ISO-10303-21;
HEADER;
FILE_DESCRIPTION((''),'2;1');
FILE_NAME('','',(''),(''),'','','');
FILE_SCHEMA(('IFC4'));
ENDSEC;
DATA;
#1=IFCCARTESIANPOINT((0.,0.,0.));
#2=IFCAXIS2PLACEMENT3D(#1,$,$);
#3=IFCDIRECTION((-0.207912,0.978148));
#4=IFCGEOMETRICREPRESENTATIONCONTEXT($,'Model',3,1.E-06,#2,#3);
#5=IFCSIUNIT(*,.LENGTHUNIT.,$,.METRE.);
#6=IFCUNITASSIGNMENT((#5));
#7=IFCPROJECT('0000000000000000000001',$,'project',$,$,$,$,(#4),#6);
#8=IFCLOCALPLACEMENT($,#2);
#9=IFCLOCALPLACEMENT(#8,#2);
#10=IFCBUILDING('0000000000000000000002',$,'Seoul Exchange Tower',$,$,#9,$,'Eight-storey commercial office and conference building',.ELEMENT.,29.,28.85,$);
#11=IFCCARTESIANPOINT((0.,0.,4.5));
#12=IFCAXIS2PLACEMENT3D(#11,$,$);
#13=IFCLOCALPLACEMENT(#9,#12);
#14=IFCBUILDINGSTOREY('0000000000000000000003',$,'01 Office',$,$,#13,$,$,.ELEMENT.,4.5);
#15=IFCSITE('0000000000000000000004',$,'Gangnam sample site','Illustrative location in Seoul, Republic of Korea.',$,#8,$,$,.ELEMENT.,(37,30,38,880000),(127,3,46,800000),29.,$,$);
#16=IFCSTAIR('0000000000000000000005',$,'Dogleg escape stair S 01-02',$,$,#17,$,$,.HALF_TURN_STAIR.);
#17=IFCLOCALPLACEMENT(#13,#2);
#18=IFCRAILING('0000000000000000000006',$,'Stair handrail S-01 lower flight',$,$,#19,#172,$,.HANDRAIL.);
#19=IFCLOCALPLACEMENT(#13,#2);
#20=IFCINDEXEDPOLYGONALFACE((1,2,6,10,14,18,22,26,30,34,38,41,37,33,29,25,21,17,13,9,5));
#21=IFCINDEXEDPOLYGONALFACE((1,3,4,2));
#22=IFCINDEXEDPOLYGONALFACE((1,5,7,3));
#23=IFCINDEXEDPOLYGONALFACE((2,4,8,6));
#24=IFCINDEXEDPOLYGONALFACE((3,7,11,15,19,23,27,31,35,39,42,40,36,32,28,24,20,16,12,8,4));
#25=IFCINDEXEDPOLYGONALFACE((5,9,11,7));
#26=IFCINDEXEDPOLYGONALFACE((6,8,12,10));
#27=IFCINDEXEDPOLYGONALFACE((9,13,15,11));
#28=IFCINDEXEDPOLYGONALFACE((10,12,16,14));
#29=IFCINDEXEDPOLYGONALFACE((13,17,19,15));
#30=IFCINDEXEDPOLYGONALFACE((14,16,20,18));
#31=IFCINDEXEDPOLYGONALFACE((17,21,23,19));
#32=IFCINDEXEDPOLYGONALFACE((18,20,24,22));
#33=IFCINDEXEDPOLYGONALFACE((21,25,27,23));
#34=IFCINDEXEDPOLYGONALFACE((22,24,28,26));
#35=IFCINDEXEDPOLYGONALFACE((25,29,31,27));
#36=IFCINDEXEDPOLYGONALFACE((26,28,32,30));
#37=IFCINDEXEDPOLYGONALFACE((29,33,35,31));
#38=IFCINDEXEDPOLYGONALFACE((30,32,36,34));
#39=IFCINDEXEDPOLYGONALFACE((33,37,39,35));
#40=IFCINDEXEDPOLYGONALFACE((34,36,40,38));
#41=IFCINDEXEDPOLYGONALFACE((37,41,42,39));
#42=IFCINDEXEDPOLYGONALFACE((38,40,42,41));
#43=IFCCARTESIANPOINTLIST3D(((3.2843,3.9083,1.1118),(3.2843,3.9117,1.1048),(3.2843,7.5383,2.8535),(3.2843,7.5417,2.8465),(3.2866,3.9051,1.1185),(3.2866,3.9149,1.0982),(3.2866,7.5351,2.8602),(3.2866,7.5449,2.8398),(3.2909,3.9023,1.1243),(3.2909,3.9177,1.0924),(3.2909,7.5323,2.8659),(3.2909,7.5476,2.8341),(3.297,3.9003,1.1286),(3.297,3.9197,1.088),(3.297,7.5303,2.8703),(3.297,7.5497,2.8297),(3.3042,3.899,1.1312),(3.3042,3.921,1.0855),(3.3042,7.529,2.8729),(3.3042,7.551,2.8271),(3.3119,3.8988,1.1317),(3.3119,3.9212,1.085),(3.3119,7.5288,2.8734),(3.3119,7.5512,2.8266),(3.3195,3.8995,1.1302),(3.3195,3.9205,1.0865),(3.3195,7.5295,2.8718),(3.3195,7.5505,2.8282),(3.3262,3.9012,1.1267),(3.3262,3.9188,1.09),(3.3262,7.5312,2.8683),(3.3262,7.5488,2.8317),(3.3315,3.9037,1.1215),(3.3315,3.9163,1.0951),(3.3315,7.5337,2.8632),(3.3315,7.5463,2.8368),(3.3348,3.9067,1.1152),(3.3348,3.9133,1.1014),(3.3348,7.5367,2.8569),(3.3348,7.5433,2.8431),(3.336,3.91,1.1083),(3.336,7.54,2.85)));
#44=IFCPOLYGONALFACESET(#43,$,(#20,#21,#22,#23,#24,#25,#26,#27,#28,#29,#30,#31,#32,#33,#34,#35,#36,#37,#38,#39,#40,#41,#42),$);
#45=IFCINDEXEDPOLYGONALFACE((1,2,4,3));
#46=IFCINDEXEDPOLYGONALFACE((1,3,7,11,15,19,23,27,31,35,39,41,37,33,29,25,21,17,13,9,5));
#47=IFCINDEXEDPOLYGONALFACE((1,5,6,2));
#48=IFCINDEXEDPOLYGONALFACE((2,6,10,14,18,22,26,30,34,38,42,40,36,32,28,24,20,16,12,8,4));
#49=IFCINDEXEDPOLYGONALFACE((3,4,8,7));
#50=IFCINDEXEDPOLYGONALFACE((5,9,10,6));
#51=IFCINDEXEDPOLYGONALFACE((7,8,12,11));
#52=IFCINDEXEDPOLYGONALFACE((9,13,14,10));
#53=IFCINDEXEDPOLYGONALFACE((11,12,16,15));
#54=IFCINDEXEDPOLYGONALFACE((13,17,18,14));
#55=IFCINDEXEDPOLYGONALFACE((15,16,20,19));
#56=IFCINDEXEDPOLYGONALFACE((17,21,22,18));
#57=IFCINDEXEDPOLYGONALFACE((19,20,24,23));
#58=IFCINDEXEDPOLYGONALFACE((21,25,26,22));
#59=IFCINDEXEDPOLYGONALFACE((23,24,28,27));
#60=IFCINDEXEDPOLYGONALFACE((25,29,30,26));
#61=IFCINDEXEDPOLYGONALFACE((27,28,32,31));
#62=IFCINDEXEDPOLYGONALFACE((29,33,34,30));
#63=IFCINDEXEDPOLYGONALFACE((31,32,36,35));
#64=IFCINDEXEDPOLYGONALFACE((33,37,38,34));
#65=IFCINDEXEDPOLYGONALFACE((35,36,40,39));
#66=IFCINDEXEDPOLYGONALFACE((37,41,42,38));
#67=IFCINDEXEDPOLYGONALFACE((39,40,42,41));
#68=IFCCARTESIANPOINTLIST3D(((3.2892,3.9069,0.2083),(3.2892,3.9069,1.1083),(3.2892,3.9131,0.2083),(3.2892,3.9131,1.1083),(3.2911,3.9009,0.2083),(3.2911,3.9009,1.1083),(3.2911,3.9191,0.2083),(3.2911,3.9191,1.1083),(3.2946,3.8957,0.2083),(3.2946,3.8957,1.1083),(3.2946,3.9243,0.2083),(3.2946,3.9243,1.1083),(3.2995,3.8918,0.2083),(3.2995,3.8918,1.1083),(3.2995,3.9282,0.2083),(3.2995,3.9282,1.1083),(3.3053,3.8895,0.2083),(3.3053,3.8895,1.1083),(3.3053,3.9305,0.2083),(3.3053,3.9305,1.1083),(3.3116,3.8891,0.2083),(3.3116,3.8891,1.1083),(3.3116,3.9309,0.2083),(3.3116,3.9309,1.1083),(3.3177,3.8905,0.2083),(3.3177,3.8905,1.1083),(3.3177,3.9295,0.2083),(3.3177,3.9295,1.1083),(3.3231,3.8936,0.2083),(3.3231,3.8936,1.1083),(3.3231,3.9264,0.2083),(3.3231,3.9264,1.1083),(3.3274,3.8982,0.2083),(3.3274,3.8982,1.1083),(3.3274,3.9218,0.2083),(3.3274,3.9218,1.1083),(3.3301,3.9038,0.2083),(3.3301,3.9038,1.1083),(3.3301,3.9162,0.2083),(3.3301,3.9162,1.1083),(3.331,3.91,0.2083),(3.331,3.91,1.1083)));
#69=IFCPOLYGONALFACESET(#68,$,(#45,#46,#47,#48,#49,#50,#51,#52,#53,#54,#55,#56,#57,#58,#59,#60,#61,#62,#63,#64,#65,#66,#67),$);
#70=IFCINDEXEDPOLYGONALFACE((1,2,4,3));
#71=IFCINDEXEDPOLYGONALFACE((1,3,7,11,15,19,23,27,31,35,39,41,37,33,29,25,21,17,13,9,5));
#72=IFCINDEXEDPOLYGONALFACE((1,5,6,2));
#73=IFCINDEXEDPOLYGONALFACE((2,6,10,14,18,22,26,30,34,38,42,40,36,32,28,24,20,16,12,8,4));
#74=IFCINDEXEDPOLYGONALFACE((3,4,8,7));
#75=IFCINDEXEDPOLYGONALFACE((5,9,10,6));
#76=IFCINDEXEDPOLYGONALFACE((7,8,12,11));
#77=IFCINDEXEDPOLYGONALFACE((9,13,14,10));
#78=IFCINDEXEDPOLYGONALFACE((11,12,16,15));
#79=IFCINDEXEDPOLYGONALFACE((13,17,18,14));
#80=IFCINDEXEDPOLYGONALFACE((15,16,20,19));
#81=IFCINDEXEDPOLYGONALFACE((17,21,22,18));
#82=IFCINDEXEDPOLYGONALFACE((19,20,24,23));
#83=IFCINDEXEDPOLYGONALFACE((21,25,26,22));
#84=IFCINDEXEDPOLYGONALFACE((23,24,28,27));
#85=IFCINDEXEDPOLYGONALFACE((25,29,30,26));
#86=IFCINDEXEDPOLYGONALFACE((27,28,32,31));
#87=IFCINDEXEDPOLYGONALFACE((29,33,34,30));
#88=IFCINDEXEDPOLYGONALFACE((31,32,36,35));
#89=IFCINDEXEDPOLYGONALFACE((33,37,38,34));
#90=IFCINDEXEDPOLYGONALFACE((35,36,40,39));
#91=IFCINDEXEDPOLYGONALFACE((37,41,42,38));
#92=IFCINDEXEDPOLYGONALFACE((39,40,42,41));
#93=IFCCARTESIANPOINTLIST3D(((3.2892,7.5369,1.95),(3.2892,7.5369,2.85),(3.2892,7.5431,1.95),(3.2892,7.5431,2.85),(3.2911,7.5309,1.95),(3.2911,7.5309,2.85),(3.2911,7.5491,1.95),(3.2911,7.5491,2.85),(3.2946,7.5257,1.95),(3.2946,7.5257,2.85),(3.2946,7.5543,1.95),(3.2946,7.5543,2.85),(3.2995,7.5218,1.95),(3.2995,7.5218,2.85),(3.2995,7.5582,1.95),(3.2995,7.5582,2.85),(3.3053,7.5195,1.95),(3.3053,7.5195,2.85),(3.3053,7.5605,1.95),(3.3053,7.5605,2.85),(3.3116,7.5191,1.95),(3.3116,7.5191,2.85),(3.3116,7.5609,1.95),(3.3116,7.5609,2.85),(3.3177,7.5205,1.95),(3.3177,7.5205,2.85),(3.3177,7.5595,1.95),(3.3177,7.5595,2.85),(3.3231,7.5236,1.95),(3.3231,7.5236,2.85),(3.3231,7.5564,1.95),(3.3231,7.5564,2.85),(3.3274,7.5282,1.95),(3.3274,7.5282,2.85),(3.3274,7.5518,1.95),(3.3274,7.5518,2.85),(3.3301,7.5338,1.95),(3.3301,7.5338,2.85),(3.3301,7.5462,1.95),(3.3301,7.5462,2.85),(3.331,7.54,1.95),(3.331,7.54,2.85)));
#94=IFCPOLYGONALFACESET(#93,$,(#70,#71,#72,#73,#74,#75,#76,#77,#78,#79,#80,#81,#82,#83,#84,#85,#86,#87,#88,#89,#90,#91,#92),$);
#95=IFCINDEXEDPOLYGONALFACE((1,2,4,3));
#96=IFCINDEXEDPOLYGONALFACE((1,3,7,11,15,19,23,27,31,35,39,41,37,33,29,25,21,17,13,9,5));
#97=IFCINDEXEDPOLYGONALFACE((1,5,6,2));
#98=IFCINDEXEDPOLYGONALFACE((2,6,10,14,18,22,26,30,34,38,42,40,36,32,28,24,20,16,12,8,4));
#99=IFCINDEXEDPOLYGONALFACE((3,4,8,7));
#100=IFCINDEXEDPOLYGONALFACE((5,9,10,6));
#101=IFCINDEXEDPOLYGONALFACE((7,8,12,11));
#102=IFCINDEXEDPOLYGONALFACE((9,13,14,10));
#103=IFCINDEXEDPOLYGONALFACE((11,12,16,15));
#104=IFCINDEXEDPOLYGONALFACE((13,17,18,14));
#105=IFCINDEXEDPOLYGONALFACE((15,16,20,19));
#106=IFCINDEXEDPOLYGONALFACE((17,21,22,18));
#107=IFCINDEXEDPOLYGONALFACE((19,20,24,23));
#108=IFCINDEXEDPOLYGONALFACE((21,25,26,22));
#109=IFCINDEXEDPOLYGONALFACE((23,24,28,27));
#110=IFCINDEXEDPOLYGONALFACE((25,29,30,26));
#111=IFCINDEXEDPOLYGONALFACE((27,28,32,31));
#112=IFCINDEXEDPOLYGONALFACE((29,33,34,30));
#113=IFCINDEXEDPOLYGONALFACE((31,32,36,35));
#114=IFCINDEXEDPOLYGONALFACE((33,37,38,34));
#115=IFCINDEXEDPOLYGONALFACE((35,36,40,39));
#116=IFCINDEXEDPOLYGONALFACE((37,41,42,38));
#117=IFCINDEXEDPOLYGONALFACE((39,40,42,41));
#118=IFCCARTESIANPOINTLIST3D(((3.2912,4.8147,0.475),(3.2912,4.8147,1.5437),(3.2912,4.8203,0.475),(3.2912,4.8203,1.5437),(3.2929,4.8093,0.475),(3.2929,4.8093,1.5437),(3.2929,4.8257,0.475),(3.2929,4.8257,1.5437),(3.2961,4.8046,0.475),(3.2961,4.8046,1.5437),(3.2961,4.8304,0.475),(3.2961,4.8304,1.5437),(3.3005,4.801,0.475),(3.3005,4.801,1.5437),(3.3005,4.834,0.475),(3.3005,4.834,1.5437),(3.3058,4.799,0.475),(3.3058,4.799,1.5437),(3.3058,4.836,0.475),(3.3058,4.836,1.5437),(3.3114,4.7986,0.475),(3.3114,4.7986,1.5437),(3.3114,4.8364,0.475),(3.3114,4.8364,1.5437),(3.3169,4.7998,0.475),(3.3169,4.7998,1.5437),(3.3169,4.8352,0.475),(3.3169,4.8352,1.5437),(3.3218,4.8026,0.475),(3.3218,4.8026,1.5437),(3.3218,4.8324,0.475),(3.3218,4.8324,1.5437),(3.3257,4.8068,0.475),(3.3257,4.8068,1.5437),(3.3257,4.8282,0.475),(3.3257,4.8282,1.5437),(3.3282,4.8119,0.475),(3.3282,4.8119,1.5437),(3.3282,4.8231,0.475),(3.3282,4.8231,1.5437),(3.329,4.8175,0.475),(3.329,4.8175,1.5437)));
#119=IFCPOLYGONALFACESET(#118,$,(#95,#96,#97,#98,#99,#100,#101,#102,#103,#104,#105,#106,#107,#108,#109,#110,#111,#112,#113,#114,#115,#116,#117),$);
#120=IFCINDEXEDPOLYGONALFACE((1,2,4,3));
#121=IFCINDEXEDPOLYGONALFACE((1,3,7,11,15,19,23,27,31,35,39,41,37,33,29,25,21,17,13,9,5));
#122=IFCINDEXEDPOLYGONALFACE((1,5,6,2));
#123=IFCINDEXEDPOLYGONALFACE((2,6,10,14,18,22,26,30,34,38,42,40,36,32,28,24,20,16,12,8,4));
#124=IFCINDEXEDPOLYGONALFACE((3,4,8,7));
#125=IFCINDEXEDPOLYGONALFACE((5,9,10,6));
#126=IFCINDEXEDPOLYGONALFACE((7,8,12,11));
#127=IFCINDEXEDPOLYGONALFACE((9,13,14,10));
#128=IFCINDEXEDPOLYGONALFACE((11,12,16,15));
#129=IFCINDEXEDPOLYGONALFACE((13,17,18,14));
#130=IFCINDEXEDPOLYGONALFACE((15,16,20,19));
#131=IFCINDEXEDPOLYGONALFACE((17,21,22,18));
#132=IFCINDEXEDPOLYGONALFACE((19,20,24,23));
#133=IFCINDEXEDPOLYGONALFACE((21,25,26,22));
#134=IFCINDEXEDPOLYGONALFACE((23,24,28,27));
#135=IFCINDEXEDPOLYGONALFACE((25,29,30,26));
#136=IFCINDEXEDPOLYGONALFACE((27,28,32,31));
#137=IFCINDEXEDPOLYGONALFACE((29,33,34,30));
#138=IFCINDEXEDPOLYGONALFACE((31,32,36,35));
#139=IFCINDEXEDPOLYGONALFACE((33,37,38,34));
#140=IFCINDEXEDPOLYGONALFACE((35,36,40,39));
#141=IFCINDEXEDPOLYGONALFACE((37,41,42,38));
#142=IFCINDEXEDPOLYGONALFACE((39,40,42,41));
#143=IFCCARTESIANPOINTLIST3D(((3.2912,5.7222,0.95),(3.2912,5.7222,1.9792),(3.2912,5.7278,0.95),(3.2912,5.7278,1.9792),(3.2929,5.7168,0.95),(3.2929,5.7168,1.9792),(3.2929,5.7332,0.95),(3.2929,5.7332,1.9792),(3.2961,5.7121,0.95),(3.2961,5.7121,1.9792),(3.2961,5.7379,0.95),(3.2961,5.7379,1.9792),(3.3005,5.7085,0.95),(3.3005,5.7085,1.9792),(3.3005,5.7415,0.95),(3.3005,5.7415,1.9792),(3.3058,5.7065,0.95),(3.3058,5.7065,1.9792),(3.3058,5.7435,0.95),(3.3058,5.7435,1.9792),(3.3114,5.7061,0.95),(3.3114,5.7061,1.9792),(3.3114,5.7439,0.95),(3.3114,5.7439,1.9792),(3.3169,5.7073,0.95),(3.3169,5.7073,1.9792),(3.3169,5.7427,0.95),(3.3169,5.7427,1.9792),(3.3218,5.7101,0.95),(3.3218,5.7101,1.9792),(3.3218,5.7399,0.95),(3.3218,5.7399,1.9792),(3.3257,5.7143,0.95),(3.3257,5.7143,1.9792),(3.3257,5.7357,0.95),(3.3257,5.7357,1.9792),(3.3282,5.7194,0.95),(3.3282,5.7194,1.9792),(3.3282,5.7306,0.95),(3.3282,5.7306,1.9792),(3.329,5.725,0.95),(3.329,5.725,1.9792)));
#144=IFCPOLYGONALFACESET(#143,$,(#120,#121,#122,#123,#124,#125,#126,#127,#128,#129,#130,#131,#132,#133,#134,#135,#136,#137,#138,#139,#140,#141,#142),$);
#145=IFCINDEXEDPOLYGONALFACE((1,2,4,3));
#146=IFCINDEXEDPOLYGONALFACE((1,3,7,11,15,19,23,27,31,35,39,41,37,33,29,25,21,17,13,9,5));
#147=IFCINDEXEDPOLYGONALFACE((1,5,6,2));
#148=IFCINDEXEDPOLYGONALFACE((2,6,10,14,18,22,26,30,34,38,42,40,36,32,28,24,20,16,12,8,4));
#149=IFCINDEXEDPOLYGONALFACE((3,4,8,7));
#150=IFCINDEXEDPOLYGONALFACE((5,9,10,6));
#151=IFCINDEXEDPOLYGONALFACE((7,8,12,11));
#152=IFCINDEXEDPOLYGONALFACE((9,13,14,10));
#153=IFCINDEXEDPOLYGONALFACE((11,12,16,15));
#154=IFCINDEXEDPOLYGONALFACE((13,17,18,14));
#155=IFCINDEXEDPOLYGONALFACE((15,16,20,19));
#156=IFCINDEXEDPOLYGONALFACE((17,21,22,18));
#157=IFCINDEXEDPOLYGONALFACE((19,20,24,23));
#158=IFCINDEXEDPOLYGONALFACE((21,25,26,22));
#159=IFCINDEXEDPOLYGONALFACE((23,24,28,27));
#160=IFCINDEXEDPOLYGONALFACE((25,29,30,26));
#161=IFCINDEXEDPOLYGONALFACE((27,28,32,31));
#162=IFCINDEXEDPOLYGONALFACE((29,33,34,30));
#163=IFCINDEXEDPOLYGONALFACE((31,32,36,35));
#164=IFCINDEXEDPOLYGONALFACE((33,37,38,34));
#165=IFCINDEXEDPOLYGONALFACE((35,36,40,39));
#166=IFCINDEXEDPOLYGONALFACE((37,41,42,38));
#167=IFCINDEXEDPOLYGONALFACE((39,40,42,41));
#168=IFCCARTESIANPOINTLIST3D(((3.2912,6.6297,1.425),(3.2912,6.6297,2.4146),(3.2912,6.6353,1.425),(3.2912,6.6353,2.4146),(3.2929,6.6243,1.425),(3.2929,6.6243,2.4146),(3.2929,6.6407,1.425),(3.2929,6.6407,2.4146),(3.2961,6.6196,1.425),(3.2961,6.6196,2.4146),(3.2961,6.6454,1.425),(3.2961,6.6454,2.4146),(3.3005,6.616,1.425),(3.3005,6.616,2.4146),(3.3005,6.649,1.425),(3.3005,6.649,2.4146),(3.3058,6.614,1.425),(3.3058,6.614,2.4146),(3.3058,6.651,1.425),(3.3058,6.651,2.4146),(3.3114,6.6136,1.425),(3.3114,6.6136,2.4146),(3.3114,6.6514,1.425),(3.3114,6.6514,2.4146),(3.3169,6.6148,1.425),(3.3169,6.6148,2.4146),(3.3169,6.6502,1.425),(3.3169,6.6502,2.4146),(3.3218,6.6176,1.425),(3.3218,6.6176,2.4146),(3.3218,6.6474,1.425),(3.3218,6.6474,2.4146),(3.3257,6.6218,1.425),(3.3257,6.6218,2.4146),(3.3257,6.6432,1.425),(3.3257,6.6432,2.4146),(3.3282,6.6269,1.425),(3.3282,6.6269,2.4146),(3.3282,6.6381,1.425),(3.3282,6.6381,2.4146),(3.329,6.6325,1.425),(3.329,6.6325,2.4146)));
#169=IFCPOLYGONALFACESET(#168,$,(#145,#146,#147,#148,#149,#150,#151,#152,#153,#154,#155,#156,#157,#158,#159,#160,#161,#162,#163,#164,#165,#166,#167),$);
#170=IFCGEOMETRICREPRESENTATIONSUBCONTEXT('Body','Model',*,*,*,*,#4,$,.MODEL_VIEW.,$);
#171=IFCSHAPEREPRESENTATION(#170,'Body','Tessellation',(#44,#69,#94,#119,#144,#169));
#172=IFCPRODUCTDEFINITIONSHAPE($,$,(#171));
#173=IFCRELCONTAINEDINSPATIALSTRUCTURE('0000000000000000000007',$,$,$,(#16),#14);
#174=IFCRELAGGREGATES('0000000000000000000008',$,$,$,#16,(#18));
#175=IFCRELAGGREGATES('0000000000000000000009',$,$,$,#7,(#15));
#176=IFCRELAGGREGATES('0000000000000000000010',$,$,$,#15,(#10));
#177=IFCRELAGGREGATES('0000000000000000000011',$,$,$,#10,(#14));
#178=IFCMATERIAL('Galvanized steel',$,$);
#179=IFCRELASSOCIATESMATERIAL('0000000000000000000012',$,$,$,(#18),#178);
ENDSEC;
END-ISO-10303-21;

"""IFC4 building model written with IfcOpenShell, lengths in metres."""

from ifc_helpers import new_model, si_unit, direction, frame, origin, place, context, subcontext, project, spatial, circle, extrude, material, element, aggregate, save


model = new_model("IFC4")

# Units and contexts
model_context = context("Model", 3, precision=1e-06, world=origin(), true_north=direction((-0.207912, 0.978148)))
body_context = subcontext(model_context, "Body", "Model", "MODEL_VIEW")
ifc_project = project(units=[si_unit("LENGTHUNIT", "METRE")], contexts=[model_context])

# Site, building, storey
site_placement = place(None, origin())
site = spatial("IfcSite", under=ifc_project, at=site_placement, Name="Gangnam sample site", Description="Illustrative location in Seoul, Republic of Korea.", CompositionType="ELEMENT", RefLatitude=(37, 30, 38, 880000), RefLongitude=(127, 3, 46, 800000), RefElevation=29.0)
building_placement = place(site_placement, origin())
building = spatial("IfcBuilding", under=site, at=building_placement, Name="Seoul Exchange Tower", LongName="Eight-storey commercial office and conference building", CompositionType="ELEMENT", ElevationOfRefHeight=29.0, ElevationOfTerrain=28.85)
storey_placement = place(building_placement, frame((0.0, 0.0, 4.5)))
storey = spatial("IfcBuildingStorey", under=building, at=storey_placement, Name="01 Office", CompositionType="ELEMENT", Elevation=4.5)

# Shared definitions
placement_1 = place(storey_placement, origin())

# Stair
placement_2 = place(placement_1, origin())
stair_1 = element("IfcStair", 1, at=placement_1, inside=storey, Name="Dogleg escape stair S 01-02", PredefinedType="HALF_TURN_STAIR")

# Railing
ifc_material_1 = material(Name="Galvanized steel")
railing_1 = element("IfcRailing", 2, at=placement_2, material=ifc_material_1, Name="Stair handrail S-01 lower flight", PredefinedType="HANDRAIL", context=body_context, shape_type="SweptSolid", body=[
    extrude(circle(Radius=0.026), frame((3.31, 3.91, 1.1083), z_axis=(0.0, 0.901594, 0.432583), x_axis=(1.0, 0.0, 0.0)), (0.0, 0.0, 1.0), 4.0262),
    extrude(circle(Radius=0.021), frame((3.31, 3.91, 0.2083), z_axis=(0.0, 0.0, 1.0), x_axis=(1.0, 0.0, 0.0)), (0.0, 0.0, 1.0), 0.9),
    extrude(circle(Radius=0.021), frame((3.31, 7.54, 1.95), z_axis=(0.0, 0.0, 1.0), x_axis=(1.0, 0.0, 0.0)), (0.0, 0.0, 1.0), 0.9),
    extrude(circle(Radius=0.019), frame((3.31, 4.8175, 0.475), z_axis=(0.0, 0.0, 1.0), x_axis=(1.0, 0.0, 0.0)), (0.0, 0.0, 1.0), 1.0688),
    extrude(circle(Radius=0.019), frame((3.31, 5.725, 0.95), z_axis=(0.0, 0.0, 1.0), x_axis=(1.0, 0.0, 0.0)), (0.0, 0.0, 1.0), 1.0292),
    extrude(circle(Radius=0.019), frame((3.31, 6.6325, 1.425), z_axis=(0.0, 0.0, 1.0), x_axis=(1.0, 0.0, 0.0)), (0.0, 0.0, 1.0), 0.9896),
])
aggregate(stair_1, [railing_1])

save(model, "model.ifc")
